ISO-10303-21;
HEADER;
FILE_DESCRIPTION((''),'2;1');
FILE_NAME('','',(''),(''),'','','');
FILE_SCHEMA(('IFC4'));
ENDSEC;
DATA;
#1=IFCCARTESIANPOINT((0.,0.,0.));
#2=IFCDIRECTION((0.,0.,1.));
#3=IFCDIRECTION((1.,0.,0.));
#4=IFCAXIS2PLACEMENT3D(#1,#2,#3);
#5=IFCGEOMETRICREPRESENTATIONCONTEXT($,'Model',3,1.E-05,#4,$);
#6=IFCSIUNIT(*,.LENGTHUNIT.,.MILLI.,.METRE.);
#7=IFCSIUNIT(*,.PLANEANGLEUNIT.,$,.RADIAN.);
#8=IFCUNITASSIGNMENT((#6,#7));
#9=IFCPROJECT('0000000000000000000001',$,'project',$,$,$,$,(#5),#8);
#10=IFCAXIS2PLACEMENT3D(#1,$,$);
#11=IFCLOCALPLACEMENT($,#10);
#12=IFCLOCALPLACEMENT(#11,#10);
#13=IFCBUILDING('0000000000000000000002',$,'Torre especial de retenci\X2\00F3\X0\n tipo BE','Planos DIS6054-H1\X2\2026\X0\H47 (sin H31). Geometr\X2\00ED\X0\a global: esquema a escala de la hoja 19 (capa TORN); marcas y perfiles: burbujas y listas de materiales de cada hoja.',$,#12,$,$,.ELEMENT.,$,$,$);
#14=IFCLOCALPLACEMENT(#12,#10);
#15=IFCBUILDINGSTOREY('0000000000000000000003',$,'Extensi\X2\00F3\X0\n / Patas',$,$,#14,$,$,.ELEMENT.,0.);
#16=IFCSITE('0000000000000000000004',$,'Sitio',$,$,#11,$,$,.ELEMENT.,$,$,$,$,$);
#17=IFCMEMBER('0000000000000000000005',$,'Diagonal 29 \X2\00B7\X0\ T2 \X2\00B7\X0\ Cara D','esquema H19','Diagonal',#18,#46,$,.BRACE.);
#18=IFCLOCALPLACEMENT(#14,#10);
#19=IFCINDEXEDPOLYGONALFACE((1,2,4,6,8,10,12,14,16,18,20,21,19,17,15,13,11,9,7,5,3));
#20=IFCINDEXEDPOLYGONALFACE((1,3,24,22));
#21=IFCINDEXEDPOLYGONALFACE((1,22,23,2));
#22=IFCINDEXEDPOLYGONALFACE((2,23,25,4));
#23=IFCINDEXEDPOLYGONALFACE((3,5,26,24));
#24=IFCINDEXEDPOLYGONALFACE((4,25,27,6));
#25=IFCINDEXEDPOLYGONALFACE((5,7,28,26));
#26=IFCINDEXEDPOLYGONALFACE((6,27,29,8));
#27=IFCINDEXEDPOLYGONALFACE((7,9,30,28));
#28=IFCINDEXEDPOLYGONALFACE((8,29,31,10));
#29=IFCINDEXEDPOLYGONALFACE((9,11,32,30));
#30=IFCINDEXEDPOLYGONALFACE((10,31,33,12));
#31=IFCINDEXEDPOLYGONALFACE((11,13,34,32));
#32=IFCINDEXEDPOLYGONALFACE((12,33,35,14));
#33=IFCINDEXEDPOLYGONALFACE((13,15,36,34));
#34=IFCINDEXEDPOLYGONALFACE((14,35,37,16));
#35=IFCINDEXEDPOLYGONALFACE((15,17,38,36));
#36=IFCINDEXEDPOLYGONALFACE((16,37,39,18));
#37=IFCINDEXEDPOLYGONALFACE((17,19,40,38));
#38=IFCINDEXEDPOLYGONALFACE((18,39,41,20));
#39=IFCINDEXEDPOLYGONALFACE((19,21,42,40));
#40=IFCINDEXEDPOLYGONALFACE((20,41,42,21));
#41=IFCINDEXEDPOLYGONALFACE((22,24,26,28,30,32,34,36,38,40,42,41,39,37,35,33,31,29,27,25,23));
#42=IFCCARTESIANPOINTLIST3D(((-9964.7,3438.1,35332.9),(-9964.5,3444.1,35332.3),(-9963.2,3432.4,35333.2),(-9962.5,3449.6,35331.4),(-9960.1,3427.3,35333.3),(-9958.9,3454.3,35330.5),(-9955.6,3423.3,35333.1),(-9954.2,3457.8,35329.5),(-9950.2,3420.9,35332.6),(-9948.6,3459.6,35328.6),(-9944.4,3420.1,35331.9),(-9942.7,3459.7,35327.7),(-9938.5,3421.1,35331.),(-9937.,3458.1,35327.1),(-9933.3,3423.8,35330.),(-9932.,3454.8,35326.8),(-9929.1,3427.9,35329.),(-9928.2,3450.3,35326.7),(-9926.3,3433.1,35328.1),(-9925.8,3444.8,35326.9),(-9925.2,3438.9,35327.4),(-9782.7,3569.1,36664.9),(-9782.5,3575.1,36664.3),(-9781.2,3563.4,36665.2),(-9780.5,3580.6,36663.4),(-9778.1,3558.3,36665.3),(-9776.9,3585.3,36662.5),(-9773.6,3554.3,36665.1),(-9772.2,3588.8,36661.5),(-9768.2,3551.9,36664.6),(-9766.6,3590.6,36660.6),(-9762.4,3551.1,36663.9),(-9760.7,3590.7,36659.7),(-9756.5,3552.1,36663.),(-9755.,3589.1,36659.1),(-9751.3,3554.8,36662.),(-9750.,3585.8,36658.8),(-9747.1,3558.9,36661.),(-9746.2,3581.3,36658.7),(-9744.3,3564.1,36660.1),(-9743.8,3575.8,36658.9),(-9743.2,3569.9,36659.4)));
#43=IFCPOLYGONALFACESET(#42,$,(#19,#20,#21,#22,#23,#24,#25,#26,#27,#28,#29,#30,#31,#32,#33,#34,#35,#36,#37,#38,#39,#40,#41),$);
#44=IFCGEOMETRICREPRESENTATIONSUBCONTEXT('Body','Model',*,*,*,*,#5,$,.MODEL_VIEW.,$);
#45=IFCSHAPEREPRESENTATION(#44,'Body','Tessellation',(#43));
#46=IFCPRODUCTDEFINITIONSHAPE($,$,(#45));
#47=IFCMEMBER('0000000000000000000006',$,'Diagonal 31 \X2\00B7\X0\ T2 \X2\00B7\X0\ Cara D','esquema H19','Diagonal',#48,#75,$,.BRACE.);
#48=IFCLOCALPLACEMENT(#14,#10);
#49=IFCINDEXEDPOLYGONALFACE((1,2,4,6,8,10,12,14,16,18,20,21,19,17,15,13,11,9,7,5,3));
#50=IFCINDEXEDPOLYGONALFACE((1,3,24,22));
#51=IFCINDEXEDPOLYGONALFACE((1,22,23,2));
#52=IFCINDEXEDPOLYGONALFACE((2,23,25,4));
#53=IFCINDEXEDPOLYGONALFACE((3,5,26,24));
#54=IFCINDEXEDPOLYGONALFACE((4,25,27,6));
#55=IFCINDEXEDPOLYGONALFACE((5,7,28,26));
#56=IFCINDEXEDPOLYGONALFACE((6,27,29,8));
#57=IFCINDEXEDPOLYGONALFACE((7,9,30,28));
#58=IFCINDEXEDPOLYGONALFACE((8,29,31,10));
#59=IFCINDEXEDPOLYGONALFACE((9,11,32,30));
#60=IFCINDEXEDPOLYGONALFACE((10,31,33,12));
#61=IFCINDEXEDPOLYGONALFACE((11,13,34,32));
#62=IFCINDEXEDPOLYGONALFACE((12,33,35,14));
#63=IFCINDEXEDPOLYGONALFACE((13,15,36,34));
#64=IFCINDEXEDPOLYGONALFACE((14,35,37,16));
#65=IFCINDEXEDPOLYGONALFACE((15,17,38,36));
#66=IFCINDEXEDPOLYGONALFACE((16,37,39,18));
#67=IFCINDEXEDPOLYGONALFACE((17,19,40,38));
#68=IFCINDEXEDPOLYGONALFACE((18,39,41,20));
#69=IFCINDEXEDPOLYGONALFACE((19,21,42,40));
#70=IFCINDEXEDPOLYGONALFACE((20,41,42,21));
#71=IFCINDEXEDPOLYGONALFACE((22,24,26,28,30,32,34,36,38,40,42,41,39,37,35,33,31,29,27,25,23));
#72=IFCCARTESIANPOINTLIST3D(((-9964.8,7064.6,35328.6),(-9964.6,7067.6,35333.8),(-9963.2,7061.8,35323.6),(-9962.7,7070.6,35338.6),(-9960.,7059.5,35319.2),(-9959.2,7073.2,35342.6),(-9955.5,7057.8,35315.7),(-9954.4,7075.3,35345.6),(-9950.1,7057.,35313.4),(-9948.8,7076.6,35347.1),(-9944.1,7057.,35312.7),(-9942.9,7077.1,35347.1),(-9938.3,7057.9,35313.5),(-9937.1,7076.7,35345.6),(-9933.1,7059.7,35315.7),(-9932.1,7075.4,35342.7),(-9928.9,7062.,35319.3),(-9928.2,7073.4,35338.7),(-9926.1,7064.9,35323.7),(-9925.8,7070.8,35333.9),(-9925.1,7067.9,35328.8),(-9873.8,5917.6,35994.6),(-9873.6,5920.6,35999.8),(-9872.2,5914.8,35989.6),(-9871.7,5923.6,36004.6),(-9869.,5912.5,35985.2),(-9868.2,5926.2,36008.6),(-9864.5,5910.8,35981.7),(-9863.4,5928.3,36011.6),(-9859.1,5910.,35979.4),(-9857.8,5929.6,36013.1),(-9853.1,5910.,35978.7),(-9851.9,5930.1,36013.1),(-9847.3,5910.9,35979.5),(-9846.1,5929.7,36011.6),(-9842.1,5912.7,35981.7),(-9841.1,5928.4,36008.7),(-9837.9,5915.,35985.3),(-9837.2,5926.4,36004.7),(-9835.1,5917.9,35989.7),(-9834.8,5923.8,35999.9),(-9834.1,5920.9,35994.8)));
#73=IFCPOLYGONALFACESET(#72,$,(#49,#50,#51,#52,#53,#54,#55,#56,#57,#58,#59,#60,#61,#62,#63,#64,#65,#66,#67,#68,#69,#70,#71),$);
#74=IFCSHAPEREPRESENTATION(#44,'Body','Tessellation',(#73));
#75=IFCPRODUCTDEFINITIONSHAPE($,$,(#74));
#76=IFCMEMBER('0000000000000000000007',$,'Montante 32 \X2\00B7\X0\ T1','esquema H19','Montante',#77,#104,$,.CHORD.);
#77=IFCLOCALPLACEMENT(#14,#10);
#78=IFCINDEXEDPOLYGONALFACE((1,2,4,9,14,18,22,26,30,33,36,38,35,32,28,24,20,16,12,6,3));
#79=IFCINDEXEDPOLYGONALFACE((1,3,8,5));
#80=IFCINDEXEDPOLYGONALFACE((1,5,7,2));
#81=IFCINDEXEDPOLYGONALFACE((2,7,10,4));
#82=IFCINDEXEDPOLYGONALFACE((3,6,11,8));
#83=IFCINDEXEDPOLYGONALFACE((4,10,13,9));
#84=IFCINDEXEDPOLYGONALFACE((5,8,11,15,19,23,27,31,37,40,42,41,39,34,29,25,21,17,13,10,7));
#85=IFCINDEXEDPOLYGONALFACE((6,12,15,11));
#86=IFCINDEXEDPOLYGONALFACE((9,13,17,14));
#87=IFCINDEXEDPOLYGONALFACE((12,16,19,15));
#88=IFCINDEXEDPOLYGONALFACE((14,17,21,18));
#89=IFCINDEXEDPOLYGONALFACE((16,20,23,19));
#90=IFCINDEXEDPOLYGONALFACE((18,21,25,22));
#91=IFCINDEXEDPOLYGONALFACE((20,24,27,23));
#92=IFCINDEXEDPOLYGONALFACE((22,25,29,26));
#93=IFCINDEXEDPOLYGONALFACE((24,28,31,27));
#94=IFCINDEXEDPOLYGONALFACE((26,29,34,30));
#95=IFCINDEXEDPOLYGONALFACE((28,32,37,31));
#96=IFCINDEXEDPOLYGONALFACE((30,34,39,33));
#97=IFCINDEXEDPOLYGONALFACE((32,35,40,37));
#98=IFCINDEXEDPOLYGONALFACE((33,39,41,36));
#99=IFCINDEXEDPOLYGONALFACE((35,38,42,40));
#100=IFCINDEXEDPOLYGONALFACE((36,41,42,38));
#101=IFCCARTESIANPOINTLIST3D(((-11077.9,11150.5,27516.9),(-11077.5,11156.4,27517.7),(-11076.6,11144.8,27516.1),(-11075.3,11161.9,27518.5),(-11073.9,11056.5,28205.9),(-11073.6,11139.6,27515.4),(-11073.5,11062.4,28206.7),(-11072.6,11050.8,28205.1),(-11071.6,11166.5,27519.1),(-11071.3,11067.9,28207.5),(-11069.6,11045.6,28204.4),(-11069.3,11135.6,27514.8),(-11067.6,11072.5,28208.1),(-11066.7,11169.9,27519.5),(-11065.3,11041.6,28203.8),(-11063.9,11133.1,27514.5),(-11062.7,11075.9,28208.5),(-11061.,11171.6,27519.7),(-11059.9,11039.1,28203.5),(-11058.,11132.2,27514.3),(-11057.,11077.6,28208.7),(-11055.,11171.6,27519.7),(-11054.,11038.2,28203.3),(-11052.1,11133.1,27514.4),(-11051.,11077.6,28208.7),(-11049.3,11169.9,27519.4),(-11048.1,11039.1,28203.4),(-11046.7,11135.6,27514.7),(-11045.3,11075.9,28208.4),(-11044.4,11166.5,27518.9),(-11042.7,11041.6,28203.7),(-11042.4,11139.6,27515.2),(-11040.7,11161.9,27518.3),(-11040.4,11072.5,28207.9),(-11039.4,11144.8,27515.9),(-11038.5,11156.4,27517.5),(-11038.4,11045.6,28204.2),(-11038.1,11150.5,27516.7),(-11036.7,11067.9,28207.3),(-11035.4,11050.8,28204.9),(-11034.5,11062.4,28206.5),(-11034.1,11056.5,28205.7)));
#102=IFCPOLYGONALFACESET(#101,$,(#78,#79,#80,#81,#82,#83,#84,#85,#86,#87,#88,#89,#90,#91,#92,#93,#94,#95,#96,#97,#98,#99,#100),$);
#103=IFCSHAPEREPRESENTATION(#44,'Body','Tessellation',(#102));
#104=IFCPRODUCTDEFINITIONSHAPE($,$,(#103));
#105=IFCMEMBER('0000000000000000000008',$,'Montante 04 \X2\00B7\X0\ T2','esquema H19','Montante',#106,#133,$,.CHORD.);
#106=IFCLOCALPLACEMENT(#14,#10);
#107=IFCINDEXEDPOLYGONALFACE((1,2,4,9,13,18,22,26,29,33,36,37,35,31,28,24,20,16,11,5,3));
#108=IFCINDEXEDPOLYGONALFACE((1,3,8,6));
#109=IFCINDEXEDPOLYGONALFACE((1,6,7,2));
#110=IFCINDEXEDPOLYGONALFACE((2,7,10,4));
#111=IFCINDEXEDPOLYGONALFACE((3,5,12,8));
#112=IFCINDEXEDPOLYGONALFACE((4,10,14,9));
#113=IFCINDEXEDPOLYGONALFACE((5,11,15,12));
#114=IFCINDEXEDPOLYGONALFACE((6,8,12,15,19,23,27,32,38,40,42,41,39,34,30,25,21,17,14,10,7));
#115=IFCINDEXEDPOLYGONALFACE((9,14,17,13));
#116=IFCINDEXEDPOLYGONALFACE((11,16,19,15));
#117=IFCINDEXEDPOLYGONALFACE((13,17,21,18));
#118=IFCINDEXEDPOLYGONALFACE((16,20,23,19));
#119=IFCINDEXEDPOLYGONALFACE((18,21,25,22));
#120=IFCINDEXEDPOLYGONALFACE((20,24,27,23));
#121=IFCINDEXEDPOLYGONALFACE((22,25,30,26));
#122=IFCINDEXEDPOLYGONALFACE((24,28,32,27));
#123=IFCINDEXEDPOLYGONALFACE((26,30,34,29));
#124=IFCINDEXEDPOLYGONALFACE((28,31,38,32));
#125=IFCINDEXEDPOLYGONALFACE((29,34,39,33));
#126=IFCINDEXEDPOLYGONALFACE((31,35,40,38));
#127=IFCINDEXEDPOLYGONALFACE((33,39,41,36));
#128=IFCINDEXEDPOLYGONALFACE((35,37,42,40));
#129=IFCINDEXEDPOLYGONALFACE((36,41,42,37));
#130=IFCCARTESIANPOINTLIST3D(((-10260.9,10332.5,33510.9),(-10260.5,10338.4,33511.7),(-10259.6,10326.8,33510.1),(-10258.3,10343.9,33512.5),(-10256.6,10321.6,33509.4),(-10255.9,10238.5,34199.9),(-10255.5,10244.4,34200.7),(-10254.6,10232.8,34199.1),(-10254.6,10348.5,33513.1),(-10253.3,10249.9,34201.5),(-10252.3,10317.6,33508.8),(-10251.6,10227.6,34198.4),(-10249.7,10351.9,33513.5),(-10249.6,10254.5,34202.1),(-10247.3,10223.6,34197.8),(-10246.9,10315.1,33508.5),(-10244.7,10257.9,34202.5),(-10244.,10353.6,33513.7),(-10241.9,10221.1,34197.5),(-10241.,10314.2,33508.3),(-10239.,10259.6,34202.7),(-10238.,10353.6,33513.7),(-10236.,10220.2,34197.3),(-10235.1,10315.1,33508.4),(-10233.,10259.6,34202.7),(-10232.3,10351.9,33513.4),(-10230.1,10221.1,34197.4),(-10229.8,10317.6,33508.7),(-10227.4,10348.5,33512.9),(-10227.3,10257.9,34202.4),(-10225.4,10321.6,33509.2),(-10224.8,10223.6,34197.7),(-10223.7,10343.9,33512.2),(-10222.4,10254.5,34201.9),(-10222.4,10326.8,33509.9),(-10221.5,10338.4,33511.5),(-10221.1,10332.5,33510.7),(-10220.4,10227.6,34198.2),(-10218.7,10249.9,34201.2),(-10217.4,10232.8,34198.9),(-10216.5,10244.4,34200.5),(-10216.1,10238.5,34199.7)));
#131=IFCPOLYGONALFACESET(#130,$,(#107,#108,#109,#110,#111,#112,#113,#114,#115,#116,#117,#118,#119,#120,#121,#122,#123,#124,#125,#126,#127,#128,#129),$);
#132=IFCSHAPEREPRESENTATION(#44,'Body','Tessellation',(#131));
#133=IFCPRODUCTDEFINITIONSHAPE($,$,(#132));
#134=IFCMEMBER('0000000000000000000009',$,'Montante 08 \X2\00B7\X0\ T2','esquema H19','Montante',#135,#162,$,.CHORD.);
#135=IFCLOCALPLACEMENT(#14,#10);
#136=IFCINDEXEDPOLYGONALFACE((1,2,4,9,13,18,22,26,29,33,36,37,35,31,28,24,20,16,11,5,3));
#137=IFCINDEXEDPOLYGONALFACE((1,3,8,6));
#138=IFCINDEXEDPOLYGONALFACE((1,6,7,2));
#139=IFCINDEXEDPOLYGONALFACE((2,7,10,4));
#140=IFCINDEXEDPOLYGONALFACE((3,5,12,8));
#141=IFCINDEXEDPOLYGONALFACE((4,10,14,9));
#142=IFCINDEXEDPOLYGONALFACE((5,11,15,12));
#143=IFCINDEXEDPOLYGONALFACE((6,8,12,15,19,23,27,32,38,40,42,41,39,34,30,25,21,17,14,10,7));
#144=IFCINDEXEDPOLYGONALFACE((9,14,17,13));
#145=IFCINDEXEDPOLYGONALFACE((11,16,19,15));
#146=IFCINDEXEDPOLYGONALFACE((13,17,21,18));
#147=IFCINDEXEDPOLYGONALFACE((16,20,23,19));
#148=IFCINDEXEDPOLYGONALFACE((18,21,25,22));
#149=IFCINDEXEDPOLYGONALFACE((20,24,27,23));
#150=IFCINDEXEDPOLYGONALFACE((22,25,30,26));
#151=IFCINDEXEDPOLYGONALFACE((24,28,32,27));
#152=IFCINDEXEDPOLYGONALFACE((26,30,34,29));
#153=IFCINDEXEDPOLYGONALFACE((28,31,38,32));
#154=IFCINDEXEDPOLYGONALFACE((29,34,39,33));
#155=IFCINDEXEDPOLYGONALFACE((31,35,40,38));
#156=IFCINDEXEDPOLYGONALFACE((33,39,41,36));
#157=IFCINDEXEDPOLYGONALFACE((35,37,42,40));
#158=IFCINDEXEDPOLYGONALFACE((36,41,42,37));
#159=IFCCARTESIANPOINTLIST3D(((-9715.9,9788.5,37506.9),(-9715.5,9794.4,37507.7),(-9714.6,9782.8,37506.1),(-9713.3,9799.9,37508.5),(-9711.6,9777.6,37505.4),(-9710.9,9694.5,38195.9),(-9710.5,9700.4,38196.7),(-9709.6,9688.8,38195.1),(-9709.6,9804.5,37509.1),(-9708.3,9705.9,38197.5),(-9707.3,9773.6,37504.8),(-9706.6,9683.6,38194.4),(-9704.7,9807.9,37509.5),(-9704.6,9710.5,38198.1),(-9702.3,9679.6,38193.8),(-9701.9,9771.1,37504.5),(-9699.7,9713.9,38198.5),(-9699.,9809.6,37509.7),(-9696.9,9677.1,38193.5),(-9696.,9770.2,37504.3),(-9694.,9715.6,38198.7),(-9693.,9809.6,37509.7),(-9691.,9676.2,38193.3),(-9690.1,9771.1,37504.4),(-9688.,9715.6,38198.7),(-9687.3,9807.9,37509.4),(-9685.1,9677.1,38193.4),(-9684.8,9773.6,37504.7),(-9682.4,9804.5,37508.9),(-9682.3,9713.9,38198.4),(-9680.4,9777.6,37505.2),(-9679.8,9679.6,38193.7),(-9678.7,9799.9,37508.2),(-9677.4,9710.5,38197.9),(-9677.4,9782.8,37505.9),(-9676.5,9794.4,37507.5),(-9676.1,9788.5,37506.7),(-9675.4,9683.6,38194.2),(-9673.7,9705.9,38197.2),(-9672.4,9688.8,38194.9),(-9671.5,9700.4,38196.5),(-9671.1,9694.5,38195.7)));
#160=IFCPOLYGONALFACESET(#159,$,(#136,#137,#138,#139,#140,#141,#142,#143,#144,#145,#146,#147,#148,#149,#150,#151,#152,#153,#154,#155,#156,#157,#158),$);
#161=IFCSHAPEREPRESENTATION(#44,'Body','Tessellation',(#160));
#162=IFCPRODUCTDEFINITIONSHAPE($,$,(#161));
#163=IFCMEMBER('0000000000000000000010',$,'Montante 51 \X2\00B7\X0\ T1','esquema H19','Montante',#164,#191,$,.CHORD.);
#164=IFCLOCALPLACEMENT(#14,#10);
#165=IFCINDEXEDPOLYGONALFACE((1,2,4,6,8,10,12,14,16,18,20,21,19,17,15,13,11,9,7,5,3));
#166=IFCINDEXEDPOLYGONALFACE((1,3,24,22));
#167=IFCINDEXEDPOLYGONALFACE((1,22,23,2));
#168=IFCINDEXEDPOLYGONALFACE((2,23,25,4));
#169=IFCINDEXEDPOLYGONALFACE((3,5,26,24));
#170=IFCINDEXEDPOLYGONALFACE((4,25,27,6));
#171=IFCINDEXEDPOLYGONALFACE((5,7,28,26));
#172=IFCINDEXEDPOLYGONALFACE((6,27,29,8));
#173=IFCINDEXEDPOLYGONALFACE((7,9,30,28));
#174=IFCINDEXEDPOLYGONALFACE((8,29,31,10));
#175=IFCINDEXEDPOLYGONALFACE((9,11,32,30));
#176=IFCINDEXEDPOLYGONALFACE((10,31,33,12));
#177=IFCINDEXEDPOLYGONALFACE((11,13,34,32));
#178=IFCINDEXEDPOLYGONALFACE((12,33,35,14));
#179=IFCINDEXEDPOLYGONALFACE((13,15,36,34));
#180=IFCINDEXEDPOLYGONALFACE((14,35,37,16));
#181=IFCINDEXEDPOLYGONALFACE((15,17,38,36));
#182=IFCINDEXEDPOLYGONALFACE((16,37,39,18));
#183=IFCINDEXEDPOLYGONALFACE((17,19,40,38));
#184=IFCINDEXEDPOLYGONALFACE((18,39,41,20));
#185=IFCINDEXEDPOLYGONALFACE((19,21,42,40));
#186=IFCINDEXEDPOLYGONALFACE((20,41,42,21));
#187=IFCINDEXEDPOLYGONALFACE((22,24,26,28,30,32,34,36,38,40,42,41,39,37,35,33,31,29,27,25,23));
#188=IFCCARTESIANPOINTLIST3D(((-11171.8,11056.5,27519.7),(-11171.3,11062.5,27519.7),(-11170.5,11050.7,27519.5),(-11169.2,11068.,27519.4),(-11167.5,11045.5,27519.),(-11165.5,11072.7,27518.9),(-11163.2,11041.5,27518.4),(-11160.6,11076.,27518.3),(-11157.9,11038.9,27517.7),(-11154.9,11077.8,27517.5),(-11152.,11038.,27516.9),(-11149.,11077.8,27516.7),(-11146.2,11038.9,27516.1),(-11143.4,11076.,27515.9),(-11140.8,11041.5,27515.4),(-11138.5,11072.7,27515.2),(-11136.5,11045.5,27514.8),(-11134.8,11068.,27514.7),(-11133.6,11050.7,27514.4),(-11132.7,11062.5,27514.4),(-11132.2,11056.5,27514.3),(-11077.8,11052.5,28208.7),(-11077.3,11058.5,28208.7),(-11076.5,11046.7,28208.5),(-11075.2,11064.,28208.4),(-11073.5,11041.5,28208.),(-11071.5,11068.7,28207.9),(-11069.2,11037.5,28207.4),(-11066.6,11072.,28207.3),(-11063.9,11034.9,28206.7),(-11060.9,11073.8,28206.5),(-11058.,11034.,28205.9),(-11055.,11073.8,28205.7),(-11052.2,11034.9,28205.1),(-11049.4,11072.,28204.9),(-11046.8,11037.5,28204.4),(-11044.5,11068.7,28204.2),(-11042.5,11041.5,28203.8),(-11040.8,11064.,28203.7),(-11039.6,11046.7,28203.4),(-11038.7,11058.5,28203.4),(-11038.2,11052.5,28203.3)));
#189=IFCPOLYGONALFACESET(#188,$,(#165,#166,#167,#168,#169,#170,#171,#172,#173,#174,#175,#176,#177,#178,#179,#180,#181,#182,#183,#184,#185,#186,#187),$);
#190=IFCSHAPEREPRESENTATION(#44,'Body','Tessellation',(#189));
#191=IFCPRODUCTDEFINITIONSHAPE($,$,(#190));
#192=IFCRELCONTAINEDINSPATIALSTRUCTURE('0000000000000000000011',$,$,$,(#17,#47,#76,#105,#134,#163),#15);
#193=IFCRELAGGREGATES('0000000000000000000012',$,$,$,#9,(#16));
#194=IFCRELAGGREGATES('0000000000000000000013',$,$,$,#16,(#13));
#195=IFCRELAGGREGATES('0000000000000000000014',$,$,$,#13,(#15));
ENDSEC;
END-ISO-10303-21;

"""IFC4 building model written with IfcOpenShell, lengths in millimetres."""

from ifc_helpers import new_model, si_unit, frame, origin, origin_with_axes, place, context, subcontext, project, spatial, circle, extrude, element, save


model = new_model("IFC4")

# Units and contexts
model_context = context("Model", 3, precision=1e-05, world=origin_with_axes())
body_context = subcontext(model_context, "Body", "Model", "MODEL_VIEW")
ifc_project = project(units=[si_unit("LENGTHUNIT", "METRE", prefix="MILLI"), si_unit("PLANEANGLEUNIT", "RADIAN")], contexts=[model_context])

# Site, building, storey
site_placement = place(None, origin())
site = spatial("IfcSite", under=ifc_project, at=site_placement, Name="Sitio", CompositionType="ELEMENT")
building_placement = place(site_placement, origin())
building = spatial("IfcBuilding", under=site, at=building_placement, Name="Torre especial de retención tipo BE", Description="Planos DIS6054-H1…H47 (sin H31). Geometría global: esquema a escala de la hoja 19 (capa TORN); marcas y perfiles: burbujas y listas de materiales de cada hoja.", CompositionType="ELEMENT")
storey_placement = place(building_placement, origin())
storey = spatial("IfcBuildingStorey", under=building, at=storey_placement, Name="Extensión / Patas", CompositionType="ELEMENT", Elevation=0.0)

# Members
member_1_placement = place(storey_placement, frame((-9763.0, 3571.0, 36662.0), z_axis=(-0.134741, -0.096984, -0.986123), x_axis=(0.933606, -0.345872, -0.093549)))
element("IfcMember", 1, at=member_1_placement, inside=storey, Name="Diagonal 29 · T2 · Cara D", Description="esquema H19", ObjectType="Diagonal", PredefinedType="BRACE", context=body_context, shape_type="SweptSolid", body=[
    extrude(circle(Radius=20.0), None, (0.0, 0.0, 1.0), 1350.7),
])
member_2_placement = place(storey_placement, frame((-9945.0, 7067.0, 35330.0), z_axis=(0.068449, -0.862761, 0.500958), x_axis=(0.943537, -0.107151, -0.31346)))
element("IfcMember", 2, at=member_2_placement, inside=storey, Name="Diagonal 31 · T2 · Cara D", Description="esquema H19", ObjectType="Diagonal", PredefinedType="BRACE", context=body_context, shape_type="SweptSolid", body=[
    extrude(circle(Radius=20.0), None, (0.0, 0.0, 1.0), 1329.5),
])
member_3_placement = place(storey_placement, frame((-11058.0, 11152.0, 27517.0), z_axis=(0.005752, -0.135175, 0.990805), x_axis=(-0.000785, -0.990822, -0.135173)))
element("IfcMember", 3, at=member_3_placement, inside=storey, Name="Montante 32 · T1", Description="esquema H19", ObjectType="Montante", PredefinedType="CHORD", context=body_context, shape_type="SweptSolid", body=[
    extrude(circle(Radius=20.0), None, (0.0, 0.0, 1.0), 695.4),
])
for number, where, z_axis, x_axis, name in (
    (4, (-10241.0, 10334.0, 33511.0), (0.00719, -0.135174, 0.990796), (-0.000981, -0.990822, -0.13517), "Montante 04 · T2"),
    (5, (-9696.0, 9790.0, 37507.0), (0.00719, -0.135174, 0.990796), (-0.000981, -0.990822, -0.13517), "Montante 08 · T2"),
):
    element("IfcMember", number, at=place(storey_placement, frame(where, z_axis=z_axis, x_axis=x_axis)), inside=storey, Name=name, Description="esquema H19", ObjectType="Montante", PredefinedType="CHORD", context=body_context, shape_type="SweptSolid", body=[
        extrude(circle(Radius=20.0), None, (0.0, 0.0, 1.0), 695.4),
    ])
member_4_placement = place(storey_placement, frame((-11152.0, 11058.0, 27517.0), z_axis=(0.135175, -0.005752, 0.990805), x_axis=(-0.000778, -0.999983, -0.005699)))
element("IfcMember", 6, at=member_4_placement, inside=storey, Name="Montante 51 · T1", Description="esquema H19", ObjectType="Montante", PredefinedType="CHORD", context=body_context, shape_type="SweptSolid", body=[
    extrude(circle(Radius=20.0), None, (0.0, 0.0, 1.0), 695.4),
])

save(model, "model.ifc")
